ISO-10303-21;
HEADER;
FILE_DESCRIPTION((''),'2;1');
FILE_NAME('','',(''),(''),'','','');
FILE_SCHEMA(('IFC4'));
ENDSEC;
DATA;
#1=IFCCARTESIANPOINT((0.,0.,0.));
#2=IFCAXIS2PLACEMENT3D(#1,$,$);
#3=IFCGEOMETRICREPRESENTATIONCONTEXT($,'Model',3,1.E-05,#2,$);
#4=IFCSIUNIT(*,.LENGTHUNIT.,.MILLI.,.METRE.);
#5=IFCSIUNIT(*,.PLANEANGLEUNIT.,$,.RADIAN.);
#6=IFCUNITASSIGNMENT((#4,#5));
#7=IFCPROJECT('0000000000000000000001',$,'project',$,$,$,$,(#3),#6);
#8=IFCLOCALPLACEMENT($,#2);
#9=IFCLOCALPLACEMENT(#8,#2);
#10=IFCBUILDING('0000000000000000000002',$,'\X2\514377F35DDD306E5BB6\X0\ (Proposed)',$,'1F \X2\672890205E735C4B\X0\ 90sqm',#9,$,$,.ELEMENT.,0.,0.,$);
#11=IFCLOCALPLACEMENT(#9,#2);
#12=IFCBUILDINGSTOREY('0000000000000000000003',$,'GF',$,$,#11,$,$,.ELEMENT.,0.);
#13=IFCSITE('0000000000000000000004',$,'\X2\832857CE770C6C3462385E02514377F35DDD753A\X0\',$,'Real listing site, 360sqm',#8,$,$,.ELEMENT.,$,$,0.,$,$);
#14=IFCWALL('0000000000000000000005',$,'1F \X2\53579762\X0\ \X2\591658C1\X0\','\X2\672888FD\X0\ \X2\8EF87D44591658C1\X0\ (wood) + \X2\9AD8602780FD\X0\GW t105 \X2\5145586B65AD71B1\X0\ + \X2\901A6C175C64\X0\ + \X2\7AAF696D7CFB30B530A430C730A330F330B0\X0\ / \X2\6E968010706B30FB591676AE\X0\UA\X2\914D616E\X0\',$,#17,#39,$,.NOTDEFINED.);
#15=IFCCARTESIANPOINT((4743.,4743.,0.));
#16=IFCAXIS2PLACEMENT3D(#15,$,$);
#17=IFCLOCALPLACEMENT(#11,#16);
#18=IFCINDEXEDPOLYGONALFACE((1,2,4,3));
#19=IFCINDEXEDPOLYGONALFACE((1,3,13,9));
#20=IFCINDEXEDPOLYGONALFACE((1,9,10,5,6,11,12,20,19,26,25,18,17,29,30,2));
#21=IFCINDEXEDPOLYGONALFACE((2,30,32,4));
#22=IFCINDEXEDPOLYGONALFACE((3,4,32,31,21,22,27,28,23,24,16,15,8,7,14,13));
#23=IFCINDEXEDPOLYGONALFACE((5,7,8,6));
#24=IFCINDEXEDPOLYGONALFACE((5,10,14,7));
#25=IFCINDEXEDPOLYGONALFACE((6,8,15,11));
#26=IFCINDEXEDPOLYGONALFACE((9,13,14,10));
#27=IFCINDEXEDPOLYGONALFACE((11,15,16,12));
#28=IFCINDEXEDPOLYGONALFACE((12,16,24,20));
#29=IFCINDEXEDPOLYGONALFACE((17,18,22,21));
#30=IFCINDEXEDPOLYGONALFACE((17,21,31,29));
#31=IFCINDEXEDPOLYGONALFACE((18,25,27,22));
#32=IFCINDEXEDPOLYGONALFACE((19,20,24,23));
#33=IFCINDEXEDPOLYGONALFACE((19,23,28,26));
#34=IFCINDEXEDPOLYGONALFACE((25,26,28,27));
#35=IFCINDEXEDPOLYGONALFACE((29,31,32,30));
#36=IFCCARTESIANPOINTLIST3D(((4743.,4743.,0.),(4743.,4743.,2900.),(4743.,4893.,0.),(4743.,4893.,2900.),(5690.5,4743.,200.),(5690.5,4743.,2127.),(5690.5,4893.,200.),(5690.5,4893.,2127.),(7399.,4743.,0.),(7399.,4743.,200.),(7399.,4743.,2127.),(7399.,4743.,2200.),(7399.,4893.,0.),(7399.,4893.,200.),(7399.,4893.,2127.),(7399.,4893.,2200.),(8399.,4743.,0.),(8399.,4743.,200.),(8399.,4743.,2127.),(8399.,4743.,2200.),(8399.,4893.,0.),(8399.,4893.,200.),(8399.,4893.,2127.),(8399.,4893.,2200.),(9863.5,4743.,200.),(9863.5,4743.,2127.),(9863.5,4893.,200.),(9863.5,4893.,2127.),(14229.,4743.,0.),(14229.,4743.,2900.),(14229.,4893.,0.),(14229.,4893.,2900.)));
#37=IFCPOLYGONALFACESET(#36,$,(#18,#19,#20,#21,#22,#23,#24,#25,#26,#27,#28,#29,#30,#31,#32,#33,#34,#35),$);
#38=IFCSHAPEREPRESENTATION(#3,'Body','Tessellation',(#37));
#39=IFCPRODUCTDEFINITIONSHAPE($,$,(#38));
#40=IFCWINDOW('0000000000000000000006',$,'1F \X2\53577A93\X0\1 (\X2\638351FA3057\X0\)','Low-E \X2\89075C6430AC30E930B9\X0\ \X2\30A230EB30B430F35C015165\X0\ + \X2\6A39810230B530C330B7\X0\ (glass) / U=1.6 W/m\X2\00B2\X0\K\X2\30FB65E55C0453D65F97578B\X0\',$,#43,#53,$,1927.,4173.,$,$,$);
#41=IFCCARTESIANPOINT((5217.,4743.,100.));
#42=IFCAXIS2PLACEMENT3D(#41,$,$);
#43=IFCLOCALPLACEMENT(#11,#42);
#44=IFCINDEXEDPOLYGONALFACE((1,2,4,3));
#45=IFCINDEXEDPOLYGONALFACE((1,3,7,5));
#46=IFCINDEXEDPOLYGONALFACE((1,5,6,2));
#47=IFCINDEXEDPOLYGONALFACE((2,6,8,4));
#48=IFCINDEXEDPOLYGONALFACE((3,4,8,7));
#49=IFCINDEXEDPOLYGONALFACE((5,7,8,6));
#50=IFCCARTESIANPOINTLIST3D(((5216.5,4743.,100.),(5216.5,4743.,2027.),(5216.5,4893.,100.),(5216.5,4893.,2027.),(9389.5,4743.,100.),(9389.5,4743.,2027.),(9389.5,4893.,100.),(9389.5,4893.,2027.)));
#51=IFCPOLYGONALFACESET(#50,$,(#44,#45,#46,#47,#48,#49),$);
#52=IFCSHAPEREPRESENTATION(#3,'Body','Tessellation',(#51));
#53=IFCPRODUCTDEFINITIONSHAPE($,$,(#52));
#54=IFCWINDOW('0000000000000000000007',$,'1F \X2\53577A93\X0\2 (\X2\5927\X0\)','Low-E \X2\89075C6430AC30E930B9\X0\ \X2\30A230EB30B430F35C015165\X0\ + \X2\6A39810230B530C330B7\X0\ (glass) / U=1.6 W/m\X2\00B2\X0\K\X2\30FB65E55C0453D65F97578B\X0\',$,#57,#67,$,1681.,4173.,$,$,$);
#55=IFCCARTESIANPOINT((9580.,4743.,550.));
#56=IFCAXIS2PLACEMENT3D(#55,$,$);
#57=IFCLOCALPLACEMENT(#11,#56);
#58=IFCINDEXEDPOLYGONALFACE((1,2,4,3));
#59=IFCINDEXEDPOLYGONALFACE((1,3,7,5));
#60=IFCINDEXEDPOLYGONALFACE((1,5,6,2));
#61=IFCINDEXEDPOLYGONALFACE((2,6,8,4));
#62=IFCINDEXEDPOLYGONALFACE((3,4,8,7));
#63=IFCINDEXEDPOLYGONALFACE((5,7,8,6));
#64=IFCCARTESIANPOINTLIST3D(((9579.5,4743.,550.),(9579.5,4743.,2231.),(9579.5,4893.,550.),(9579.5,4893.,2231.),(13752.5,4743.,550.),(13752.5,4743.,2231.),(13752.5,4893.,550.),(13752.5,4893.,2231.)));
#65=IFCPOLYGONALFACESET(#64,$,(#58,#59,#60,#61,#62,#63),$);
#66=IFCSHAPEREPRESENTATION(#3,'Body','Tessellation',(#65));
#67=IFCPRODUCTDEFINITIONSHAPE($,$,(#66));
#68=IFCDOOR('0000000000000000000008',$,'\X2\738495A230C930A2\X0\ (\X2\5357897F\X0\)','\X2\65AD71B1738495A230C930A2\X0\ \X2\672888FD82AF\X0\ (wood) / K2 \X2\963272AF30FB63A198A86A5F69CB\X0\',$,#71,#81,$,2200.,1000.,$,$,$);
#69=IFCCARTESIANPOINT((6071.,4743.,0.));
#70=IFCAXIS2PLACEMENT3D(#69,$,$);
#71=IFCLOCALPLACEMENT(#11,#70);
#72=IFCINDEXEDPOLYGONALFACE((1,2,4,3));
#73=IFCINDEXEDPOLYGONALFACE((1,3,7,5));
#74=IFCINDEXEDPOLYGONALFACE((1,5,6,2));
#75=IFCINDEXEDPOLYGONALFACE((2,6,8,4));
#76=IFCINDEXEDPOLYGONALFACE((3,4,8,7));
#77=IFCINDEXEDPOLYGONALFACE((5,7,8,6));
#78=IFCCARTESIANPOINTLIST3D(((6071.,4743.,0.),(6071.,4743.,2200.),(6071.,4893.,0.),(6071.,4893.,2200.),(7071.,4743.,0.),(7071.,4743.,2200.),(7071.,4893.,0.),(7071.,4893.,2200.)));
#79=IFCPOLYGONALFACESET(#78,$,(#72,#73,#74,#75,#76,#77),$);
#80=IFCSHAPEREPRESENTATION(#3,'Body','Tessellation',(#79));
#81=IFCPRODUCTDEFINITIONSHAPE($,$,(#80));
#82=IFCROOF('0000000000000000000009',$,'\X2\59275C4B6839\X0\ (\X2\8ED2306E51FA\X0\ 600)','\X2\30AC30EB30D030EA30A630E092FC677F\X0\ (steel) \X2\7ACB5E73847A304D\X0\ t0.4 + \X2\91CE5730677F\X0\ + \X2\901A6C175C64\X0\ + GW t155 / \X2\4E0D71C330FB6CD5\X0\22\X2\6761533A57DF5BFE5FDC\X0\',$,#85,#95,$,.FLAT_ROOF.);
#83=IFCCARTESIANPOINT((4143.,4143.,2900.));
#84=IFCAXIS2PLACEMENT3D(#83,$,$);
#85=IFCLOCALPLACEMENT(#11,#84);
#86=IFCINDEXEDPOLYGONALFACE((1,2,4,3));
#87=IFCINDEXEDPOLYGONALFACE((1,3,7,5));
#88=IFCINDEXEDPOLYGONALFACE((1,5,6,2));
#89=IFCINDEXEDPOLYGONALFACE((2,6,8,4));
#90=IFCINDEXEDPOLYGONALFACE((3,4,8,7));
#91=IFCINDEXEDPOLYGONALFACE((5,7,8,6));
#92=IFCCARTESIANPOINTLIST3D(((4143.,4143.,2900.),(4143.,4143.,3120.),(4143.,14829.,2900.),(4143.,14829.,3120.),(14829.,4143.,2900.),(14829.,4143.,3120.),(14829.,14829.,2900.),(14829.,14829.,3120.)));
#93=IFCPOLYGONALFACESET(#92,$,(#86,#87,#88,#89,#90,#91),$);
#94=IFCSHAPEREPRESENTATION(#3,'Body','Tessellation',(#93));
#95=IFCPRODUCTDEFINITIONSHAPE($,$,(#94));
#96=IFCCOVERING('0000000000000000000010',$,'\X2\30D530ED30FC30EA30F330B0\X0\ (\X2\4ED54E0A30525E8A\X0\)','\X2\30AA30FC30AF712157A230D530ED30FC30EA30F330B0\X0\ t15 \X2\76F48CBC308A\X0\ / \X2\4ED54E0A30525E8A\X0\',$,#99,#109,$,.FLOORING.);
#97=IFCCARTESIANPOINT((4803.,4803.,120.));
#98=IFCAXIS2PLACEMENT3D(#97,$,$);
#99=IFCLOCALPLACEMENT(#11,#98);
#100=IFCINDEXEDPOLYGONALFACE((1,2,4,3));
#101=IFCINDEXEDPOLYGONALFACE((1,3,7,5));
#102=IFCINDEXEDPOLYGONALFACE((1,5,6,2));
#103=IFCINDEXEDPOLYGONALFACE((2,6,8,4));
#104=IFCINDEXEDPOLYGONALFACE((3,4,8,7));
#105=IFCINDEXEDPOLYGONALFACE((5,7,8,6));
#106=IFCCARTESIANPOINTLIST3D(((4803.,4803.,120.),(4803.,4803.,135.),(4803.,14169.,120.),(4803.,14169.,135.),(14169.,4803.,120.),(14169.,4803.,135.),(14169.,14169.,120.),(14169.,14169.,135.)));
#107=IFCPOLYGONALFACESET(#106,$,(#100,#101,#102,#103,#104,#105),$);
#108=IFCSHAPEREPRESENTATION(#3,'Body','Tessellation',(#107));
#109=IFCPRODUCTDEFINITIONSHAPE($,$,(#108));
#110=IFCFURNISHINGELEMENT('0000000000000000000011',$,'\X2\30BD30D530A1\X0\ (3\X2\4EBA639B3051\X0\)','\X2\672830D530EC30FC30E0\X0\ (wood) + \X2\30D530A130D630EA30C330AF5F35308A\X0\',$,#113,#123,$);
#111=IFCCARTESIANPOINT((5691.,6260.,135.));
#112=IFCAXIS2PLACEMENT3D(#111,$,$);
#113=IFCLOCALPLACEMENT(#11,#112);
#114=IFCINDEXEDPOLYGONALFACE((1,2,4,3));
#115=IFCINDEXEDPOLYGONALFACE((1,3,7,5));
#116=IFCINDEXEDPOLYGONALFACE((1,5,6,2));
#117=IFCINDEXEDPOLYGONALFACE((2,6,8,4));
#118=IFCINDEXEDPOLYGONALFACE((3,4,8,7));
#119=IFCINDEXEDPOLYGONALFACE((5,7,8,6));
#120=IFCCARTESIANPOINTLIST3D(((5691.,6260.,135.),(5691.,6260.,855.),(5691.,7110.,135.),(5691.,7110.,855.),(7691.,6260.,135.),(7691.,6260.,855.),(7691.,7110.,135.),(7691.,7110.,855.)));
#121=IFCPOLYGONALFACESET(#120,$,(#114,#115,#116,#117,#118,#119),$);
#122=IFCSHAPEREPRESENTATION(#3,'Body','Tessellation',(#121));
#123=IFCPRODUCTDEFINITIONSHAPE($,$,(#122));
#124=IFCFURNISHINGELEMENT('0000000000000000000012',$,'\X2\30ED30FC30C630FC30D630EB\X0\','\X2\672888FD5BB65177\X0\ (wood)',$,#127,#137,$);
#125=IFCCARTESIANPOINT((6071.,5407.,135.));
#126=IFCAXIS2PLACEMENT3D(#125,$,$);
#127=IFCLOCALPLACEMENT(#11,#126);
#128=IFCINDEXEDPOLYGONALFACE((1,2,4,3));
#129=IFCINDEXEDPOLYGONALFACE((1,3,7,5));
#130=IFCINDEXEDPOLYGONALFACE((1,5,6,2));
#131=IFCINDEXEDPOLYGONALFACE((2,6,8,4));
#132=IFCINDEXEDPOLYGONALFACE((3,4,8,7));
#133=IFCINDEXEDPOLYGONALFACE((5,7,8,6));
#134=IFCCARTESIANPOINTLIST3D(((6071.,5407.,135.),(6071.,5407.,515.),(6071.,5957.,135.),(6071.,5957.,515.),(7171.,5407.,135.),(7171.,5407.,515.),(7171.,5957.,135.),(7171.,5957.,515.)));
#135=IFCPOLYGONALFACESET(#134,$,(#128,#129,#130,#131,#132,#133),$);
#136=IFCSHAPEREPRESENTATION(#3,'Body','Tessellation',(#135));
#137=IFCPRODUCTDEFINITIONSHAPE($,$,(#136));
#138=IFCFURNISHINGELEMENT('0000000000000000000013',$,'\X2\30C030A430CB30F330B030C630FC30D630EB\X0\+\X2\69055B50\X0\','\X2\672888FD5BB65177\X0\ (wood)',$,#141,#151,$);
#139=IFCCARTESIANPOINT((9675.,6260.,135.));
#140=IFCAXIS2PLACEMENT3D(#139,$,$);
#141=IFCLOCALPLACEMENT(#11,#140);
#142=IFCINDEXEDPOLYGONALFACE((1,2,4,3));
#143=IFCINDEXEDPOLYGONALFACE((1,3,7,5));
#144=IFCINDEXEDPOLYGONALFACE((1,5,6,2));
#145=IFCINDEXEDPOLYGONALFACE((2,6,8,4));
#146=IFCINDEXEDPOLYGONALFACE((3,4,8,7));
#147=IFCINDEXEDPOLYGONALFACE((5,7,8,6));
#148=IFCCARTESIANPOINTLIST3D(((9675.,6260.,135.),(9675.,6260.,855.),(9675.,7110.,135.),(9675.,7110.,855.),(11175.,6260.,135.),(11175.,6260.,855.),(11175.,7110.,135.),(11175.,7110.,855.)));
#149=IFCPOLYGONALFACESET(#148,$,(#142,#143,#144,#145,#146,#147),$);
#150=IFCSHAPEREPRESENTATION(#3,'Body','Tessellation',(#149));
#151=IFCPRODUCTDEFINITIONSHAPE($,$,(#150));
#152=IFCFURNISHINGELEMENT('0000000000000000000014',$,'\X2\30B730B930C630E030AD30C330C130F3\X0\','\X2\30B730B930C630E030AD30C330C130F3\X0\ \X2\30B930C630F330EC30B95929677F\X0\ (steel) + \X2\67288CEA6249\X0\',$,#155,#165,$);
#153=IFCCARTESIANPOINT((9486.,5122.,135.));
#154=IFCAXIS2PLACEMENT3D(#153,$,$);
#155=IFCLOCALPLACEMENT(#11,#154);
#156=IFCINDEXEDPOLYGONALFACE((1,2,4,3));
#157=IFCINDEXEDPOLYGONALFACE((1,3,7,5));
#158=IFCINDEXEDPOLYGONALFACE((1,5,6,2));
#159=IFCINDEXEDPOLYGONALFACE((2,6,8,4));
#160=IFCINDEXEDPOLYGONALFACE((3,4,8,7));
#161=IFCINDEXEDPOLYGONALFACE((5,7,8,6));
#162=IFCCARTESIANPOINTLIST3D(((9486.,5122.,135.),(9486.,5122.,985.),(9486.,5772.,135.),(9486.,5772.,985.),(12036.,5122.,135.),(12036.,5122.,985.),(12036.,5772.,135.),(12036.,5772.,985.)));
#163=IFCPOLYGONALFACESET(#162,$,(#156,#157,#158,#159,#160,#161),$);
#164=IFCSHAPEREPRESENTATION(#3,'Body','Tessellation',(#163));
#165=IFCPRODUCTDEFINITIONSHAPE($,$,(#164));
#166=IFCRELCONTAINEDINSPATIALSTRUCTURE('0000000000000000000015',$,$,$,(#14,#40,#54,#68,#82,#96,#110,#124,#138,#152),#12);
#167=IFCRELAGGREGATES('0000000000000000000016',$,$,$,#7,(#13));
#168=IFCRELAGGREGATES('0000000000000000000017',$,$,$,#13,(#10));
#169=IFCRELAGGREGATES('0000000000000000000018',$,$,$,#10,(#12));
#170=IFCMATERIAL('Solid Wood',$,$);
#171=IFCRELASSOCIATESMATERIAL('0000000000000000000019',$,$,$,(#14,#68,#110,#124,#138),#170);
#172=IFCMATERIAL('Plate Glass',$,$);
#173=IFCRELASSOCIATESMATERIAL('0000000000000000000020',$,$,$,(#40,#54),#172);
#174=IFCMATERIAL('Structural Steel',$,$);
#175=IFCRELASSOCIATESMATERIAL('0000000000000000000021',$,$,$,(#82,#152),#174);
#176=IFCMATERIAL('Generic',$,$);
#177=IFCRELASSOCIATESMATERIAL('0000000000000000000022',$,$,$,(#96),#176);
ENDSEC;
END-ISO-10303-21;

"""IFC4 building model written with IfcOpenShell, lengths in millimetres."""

from ifc_helpers import new_model, si_unit, frame, frame_2d, origin, place, context, project, spatial, rectangle, extrude, material, element, fill, save


model = new_model("IFC4")

# Units and contexts
model_context = context("Model", 3, precision=1e-05, world=origin())
ifc_project = project(units=[si_unit("LENGTHUNIT", "METRE", prefix="MILLI"), si_unit("PLANEANGLEUNIT", "RADIAN")], contexts=[model_context])

# Site, building, storey
site_placement = place(None, origin())
site = spatial("IfcSite", under=ifc_project, at=site_placement, Name="茨城県水戸市元石川町", ObjectType="Real listing site, 360sqm", CompositionType="ELEMENT", RefElevation=0.0)
building_placement = place(site_placement, origin())
building = spatial("IfcBuilding", under=site, at=building_placement, Name="元石川の家 (Proposed)", ObjectType="1F 木造平屋 90sqm", CompositionType="ELEMENT", ElevationOfRefHeight=0.0, ElevationOfTerrain=0.0)
storey_placement = place(building_placement, origin())
storey = spatial("IfcBuildingStorey", under=building, at=storey_placement, Name="GF", CompositionType="ELEMENT", Elevation=0.0)

# Shared definitions
ifc_material_1 = material(Name="Solid Wood")

# Wall, openings, windows, door
wall_1_placement = place(storey_placement, frame((4743.0, 4743.0, 0.0)))
wall_1 = element("IfcWall", 1, at=wall_1_placement, inside=storey, material=ifc_material_1, Name="1F 南面 外壁", Description="木製 軸組外壁 (wood) + 高性能GW t105 充填断熱 + 通気層 + 窯業系サイディング / 準耐火・外皮UA配慮", PredefinedType="NOTDEFINED", context=model_context, shape_type="SweptSolid", body=[
    extrude(rectangle(XDim=9486.0, YDim=150.0, at=frame_2d((4743.0, 75.0))), frame((4743.0, 4743.0, 0.0)), (0.0, 0.0, 1.0), 2900.0),
])
opening_1_placement = place(storey_placement, frame((5217.0, 4743.0, 100.0)))
opening_1 = element("IfcOpeningElement", 2, at=opening_1_placement, cuts=wall_1, PredefinedType="NOTDEFINED", context=model_context, shape_type="SweptSolid", body=[
    extrude(rectangle(XDim=4173.0, YDim=150.0, at=frame_2d((2086.0, 75.0))), frame((5217.0, 4743.0, 100.0)), (0.0, 0.0, 1.0), 1927.0),
])
opening_2_placement = place(storey_placement, frame((9580.0, 4743.0, 550.0)))
opening_2 = element("IfcOpeningElement", 3, at=opening_2_placement, cuts=wall_1, PredefinedType="NOTDEFINED", context=model_context, shape_type="SweptSolid", body=[
    extrude(rectangle(XDim=4173.0, YDim=150.0, at=frame_2d((2086.0, 75.0))), frame((9580.0, 4743.0, 550.0)), (0.0, 0.0, 1.0), 1681.0),
])
opening_3_placement = place(storey_placement, frame((6071.0, 4743.0, 0.0)))
opening_3 = element("IfcOpeningElement", 4, at=opening_3_placement, cuts=wall_1, PredefinedType="NOTDEFINED", context=model_context, shape_type="SweptSolid", body=[
    extrude(rectangle(XDim=1000.0, YDim=150.0, at=frame_2d((500.0, 75.0))), frame((6071.0, 4743.0, 0.0)), (0.0, 0.0, 1.0), 2200.0),
])
ifc_material_2 = material(Name="Plate Glass")
window_1_placement = place(storey_placement, frame((5217.0, 4743.0, 100.0)))
window_1 = element("IfcWindow", 5, at=window_1_placement, inside=storey, material=ifc_material_2, Name="1F 南窓1 (掃出し)", Description="Low-E 複層ガラス アルゴン封入 + 樹脂サッシ (glass) / U=1.6 W/m²K・日射取得型", OverallHeight=1927.0, OverallWidth=4173.0, context=model_context, shape_type="SweptSolid", body=[
    extrude(rectangle(XDim=4173.0, YDim=150.0, at=frame_2d((2086.0, 75.0))), frame((5217.0, 4743.0, 100.0)), (0.0, 0.0, 1.0), 1927.0),
])
fill(opening_1, window_1)
window_2_placement = place(storey_placement, frame((9580.0, 4743.0, 550.0)))
window_2 = element("IfcWindow", 6, at=window_2_placement, inside=storey, material=ifc_material_2, Name="1F 南窓2 (大)", Description="Low-E 複層ガラス アルゴン封入 + 樹脂サッシ (glass) / U=1.6 W/m²K・日射取得型", OverallHeight=1681.0, OverallWidth=4173.0, context=model_context, shape_type="SweptSolid", body=[
    extrude(rectangle(XDim=4173.0, YDim=150.0, at=frame_2d((2086.0, 75.0))), frame((9580.0, 4743.0, 550.0)), (0.0, 0.0, 1.0), 1681.0),
])
fill(opening_2, window_2)
door_placement = place(storey_placement, frame((6071.0, 4743.0, 0.0)))
door = element("IfcDoor", 7, at=door_placement, inside=storey, material=ifc_material_1, Name="玄関ドア (南西)", Description="断熱玄関ドア 木製芯 (wood) / K2 防犯・採風機構", OverallHeight=2200.0, OverallWidth=1000.0, context=model_context, shape_type="SweptSolid", body=[
    extrude(rectangle(XDim=1000.0, YDim=150.0, at=frame_2d((500.0, 75.0))), frame((6071.0, 4743.0, 0.0)), (0.0, 0.0, 1.0), 2200.0),
])
fill(opening_3, door)

# Roof
ifc_material_3 = material(Name="Structural Steel")
roof_placement = place(storey_placement, frame((4143.0, 4143.0, 2900.0)))
element("IfcRoof", 8, at=roof_placement, inside=storey, material=ifc_material_3, Name="大屋根 (軒の出 600)", Description="ガルバリウム鋼板 (steel) 立平葺き t0.4 + 野地板 + 通気層 + GW t155 / 不燃・法22条区域対応", PredefinedType="FLAT_ROOF", context=model_context, shape_type="SweptSolid", body=[
    extrude(rectangle(XDim=10686.0, YDim=10686.0, at=frame_2d((5343.0, 5343.0))), frame((4143.0, 4143.0, 2900.0)), (0.0, 0.0, 1.0), 220.0),
])

# Covering
ifc_material_4 = material(Name="Generic")
covering_placement = place(storey_placement, frame((4803.0, 4803.0, 120.0)))
element("IfcCovering", 9, at=covering_placement, inside=storey, material=ifc_material_4, Name="フローリング (仕上げ床)", Description="オーク無垢フローリング t15 直貼り / 仕上げ床", PredefinedType="FLOORING", context=model_context, shape_type="SweptSolid", body=[
    extrude(rectangle(XDim=9366.0, YDim=9366.0, at=frame_2d((4683.0, 4683.0))), frame((4803.0, 4803.0, 120.0)), (0.0, 0.0, 1.0), 15.0),
])

# Furnishing elements
furnishing_1_placement = place(storey_placement, frame((5691.0, 6260.0, 135.0)))
element("IfcFurnishingElement", 10, at=furnishing_1_placement, inside=storey, material=ifc_material_1, Name="ソファ (3人掛け)", Description="木フレーム (wood) + ファブリック張り", context=model_context, shape_type="SweptSolid", body=[
    extrude(rectangle(XDim=2000.0, YDim=850.0, at=frame_2d((1000.0, 425.0))), frame((5691.0, 6260.0, 135.0)), (0.0, 0.0, 1.0), 720.0),
])
furnishing_2_placement = place(storey_placement, frame((6071.0, 5407.0, 135.0)))
element("IfcFurnishingElement", 11, at=furnishing_2_placement, inside=storey, material=ifc_material_1, Name="ローテーブル", Description="木製家具 (wood)", context=model_context, shape_type="SweptSolid", body=[
    extrude(rectangle(XDim=1100.0, YDim=550.0, at=frame_2d((550.0, 275.0))), frame((6071.0, 5407.0, 135.0)), (0.0, 0.0, 1.0), 380.0),
])
furnishing_3_placement = place(storey_placement, frame((9675.0, 6260.0, 135.0)))
element("IfcFurnishingElement", 12, at=furnishing_3_placement, inside=storey, material=ifc_material_1, Name="ダイニングテーブル+椅子", Description="木製家具 (wood)", context=model_context, shape_type="SweptSolid", body=[
    extrude(rectangle(XDim=1500.0, YDim=850.0, at=frame_2d((750.0, 425.0))), frame((9675.0, 6260.0, 135.0)), (0.0, 0.0, 1.0), 720.0),
])
furnishing_4_placement = place(storey_placement, frame((9486.0, 5122.0, 135.0)))
element("IfcFurnishingElement", 13, at=furnishing_4_placement, inside=storey, material=ifc_material_3, Name="システムキッチン", Description="システムキッチン ステンレス天板 (steel) + 木質扉", context=model_context, shape_type="SweptSolid", body=[
    extrude(rectangle(XDim=2550.0, YDim=650.0, at=frame_2d((1275.0, 325.0))), frame((9486.0, 5122.0, 135.0)), (0.0, 0.0, 1.0), 850.0),
])

save(model, "model.ifc")
